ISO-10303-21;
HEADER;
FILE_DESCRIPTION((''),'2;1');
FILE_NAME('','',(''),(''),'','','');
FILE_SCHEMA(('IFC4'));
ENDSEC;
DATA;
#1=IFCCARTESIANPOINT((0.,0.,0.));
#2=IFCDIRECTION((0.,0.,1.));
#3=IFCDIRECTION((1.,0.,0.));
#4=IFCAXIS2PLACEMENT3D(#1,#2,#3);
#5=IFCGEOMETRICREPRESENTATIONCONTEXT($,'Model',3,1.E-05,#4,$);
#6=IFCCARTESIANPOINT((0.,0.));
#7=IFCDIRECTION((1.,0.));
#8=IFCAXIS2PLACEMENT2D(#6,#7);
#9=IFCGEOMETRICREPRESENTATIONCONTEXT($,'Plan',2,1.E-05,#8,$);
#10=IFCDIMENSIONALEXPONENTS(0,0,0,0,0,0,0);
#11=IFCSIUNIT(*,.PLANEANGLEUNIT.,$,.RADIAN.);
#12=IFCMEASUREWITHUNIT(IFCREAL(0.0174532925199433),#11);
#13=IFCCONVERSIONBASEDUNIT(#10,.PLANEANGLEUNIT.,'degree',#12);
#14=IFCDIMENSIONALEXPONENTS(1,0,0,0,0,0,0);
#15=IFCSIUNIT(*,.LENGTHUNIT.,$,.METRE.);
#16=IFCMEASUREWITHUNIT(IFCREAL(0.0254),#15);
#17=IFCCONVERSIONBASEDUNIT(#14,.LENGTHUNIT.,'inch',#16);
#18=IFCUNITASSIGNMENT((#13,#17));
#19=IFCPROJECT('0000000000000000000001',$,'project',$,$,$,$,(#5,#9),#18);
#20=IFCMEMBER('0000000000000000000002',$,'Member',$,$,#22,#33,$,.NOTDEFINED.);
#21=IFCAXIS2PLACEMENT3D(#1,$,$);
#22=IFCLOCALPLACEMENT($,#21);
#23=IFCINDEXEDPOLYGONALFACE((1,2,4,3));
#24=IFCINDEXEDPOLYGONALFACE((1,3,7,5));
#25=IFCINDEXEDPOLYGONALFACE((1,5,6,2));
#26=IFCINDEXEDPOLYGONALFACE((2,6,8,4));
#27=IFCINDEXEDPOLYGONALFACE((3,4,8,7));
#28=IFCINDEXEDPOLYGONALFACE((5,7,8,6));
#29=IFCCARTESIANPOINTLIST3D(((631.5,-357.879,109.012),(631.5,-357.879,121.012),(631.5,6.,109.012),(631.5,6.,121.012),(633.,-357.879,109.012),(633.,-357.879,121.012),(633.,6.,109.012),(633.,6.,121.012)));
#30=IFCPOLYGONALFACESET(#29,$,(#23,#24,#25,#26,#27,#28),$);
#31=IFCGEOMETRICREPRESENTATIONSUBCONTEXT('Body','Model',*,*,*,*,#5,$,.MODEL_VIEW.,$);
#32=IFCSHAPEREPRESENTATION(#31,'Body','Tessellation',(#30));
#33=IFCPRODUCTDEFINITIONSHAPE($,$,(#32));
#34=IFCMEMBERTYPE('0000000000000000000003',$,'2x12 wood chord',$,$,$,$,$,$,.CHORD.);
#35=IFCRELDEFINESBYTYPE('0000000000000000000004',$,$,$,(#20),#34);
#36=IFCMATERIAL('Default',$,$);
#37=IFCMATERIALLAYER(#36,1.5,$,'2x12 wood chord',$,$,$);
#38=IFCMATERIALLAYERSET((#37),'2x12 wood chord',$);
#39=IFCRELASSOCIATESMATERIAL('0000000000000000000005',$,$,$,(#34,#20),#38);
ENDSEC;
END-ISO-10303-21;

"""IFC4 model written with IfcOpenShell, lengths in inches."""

from ifc_helpers import new_model, entity, si_unit, converted_unit, frame, origin_with_axes, origin_2d_with_axis, place, context, subcontext, project, indexed_curve, outline, extrude, material, layer, layer_set, layer_usage, type_object, element, save


model = new_model("IFC4")

# Units and contexts
model_context = context("Model", 3, precision=1e-05, world=origin_with_axes())
plan_context = context("Plan", 2, precision=1e-05, world=origin_2d_with_axis())
body_context = subcontext(model_context, "Body", "Model", "MODEL_VIEW")
ifc_project = project(units=[converted_unit("PLANEANGLEUNIT", "degree", entity("IfcReal", 0.0174532925199433), si_unit("PLANEANGLEUNIT", "RADIAN"), dimensions=[0, 0, 0, 0, 0, 0, 0]), converted_unit("LENGTHUNIT", "inch", entity("IfcReal", 0.0254), si_unit("LENGTHUNIT", "METRE"), dimensions=[1, 0, 0, 0, 0, 0, 0])], contexts=[model_context, plan_context])

# Member
ifc_material = material(Name="Default")
ifc_layer = layer(ifc_material, 1.5, Name="2x12 wood chord")
ifc_layer_set = layer_set([ifc_layer], Name="2x12 wood chord")
ifc_layer_usage = layer_usage(ifc_layer_set, "AXIS2", "POSITIVE", 0.0)
member_type = type_object("IfcMemberType", Name="2x12 wood chord", PredefinedType="CHORD", material=ifc_layer_set)
member_placement = place(None, frame((633.0, -357.879, 109.012), z_axis=(0.0, 0.0, 1.0), x_axis=(0.0, 1.0, 0.0)))
element("IfcMember", 1, at=member_placement, type_object=member_type, material=ifc_layer_usage, Name="Member", PredefinedType="NOTDEFINED", context=body_context, shape_type="SweptSolid", body=[
    extrude(outline(indexed_curve([(0.0, 0.0), (0.0, 1.5), (363.879, 1.5), (363.879, 0.0), (0.0, 0.0)], self_intersect=False)), origin_with_axes(), (0.0, 0.0, 1.0), 12.0),
])

save(model, "model.ifc")
